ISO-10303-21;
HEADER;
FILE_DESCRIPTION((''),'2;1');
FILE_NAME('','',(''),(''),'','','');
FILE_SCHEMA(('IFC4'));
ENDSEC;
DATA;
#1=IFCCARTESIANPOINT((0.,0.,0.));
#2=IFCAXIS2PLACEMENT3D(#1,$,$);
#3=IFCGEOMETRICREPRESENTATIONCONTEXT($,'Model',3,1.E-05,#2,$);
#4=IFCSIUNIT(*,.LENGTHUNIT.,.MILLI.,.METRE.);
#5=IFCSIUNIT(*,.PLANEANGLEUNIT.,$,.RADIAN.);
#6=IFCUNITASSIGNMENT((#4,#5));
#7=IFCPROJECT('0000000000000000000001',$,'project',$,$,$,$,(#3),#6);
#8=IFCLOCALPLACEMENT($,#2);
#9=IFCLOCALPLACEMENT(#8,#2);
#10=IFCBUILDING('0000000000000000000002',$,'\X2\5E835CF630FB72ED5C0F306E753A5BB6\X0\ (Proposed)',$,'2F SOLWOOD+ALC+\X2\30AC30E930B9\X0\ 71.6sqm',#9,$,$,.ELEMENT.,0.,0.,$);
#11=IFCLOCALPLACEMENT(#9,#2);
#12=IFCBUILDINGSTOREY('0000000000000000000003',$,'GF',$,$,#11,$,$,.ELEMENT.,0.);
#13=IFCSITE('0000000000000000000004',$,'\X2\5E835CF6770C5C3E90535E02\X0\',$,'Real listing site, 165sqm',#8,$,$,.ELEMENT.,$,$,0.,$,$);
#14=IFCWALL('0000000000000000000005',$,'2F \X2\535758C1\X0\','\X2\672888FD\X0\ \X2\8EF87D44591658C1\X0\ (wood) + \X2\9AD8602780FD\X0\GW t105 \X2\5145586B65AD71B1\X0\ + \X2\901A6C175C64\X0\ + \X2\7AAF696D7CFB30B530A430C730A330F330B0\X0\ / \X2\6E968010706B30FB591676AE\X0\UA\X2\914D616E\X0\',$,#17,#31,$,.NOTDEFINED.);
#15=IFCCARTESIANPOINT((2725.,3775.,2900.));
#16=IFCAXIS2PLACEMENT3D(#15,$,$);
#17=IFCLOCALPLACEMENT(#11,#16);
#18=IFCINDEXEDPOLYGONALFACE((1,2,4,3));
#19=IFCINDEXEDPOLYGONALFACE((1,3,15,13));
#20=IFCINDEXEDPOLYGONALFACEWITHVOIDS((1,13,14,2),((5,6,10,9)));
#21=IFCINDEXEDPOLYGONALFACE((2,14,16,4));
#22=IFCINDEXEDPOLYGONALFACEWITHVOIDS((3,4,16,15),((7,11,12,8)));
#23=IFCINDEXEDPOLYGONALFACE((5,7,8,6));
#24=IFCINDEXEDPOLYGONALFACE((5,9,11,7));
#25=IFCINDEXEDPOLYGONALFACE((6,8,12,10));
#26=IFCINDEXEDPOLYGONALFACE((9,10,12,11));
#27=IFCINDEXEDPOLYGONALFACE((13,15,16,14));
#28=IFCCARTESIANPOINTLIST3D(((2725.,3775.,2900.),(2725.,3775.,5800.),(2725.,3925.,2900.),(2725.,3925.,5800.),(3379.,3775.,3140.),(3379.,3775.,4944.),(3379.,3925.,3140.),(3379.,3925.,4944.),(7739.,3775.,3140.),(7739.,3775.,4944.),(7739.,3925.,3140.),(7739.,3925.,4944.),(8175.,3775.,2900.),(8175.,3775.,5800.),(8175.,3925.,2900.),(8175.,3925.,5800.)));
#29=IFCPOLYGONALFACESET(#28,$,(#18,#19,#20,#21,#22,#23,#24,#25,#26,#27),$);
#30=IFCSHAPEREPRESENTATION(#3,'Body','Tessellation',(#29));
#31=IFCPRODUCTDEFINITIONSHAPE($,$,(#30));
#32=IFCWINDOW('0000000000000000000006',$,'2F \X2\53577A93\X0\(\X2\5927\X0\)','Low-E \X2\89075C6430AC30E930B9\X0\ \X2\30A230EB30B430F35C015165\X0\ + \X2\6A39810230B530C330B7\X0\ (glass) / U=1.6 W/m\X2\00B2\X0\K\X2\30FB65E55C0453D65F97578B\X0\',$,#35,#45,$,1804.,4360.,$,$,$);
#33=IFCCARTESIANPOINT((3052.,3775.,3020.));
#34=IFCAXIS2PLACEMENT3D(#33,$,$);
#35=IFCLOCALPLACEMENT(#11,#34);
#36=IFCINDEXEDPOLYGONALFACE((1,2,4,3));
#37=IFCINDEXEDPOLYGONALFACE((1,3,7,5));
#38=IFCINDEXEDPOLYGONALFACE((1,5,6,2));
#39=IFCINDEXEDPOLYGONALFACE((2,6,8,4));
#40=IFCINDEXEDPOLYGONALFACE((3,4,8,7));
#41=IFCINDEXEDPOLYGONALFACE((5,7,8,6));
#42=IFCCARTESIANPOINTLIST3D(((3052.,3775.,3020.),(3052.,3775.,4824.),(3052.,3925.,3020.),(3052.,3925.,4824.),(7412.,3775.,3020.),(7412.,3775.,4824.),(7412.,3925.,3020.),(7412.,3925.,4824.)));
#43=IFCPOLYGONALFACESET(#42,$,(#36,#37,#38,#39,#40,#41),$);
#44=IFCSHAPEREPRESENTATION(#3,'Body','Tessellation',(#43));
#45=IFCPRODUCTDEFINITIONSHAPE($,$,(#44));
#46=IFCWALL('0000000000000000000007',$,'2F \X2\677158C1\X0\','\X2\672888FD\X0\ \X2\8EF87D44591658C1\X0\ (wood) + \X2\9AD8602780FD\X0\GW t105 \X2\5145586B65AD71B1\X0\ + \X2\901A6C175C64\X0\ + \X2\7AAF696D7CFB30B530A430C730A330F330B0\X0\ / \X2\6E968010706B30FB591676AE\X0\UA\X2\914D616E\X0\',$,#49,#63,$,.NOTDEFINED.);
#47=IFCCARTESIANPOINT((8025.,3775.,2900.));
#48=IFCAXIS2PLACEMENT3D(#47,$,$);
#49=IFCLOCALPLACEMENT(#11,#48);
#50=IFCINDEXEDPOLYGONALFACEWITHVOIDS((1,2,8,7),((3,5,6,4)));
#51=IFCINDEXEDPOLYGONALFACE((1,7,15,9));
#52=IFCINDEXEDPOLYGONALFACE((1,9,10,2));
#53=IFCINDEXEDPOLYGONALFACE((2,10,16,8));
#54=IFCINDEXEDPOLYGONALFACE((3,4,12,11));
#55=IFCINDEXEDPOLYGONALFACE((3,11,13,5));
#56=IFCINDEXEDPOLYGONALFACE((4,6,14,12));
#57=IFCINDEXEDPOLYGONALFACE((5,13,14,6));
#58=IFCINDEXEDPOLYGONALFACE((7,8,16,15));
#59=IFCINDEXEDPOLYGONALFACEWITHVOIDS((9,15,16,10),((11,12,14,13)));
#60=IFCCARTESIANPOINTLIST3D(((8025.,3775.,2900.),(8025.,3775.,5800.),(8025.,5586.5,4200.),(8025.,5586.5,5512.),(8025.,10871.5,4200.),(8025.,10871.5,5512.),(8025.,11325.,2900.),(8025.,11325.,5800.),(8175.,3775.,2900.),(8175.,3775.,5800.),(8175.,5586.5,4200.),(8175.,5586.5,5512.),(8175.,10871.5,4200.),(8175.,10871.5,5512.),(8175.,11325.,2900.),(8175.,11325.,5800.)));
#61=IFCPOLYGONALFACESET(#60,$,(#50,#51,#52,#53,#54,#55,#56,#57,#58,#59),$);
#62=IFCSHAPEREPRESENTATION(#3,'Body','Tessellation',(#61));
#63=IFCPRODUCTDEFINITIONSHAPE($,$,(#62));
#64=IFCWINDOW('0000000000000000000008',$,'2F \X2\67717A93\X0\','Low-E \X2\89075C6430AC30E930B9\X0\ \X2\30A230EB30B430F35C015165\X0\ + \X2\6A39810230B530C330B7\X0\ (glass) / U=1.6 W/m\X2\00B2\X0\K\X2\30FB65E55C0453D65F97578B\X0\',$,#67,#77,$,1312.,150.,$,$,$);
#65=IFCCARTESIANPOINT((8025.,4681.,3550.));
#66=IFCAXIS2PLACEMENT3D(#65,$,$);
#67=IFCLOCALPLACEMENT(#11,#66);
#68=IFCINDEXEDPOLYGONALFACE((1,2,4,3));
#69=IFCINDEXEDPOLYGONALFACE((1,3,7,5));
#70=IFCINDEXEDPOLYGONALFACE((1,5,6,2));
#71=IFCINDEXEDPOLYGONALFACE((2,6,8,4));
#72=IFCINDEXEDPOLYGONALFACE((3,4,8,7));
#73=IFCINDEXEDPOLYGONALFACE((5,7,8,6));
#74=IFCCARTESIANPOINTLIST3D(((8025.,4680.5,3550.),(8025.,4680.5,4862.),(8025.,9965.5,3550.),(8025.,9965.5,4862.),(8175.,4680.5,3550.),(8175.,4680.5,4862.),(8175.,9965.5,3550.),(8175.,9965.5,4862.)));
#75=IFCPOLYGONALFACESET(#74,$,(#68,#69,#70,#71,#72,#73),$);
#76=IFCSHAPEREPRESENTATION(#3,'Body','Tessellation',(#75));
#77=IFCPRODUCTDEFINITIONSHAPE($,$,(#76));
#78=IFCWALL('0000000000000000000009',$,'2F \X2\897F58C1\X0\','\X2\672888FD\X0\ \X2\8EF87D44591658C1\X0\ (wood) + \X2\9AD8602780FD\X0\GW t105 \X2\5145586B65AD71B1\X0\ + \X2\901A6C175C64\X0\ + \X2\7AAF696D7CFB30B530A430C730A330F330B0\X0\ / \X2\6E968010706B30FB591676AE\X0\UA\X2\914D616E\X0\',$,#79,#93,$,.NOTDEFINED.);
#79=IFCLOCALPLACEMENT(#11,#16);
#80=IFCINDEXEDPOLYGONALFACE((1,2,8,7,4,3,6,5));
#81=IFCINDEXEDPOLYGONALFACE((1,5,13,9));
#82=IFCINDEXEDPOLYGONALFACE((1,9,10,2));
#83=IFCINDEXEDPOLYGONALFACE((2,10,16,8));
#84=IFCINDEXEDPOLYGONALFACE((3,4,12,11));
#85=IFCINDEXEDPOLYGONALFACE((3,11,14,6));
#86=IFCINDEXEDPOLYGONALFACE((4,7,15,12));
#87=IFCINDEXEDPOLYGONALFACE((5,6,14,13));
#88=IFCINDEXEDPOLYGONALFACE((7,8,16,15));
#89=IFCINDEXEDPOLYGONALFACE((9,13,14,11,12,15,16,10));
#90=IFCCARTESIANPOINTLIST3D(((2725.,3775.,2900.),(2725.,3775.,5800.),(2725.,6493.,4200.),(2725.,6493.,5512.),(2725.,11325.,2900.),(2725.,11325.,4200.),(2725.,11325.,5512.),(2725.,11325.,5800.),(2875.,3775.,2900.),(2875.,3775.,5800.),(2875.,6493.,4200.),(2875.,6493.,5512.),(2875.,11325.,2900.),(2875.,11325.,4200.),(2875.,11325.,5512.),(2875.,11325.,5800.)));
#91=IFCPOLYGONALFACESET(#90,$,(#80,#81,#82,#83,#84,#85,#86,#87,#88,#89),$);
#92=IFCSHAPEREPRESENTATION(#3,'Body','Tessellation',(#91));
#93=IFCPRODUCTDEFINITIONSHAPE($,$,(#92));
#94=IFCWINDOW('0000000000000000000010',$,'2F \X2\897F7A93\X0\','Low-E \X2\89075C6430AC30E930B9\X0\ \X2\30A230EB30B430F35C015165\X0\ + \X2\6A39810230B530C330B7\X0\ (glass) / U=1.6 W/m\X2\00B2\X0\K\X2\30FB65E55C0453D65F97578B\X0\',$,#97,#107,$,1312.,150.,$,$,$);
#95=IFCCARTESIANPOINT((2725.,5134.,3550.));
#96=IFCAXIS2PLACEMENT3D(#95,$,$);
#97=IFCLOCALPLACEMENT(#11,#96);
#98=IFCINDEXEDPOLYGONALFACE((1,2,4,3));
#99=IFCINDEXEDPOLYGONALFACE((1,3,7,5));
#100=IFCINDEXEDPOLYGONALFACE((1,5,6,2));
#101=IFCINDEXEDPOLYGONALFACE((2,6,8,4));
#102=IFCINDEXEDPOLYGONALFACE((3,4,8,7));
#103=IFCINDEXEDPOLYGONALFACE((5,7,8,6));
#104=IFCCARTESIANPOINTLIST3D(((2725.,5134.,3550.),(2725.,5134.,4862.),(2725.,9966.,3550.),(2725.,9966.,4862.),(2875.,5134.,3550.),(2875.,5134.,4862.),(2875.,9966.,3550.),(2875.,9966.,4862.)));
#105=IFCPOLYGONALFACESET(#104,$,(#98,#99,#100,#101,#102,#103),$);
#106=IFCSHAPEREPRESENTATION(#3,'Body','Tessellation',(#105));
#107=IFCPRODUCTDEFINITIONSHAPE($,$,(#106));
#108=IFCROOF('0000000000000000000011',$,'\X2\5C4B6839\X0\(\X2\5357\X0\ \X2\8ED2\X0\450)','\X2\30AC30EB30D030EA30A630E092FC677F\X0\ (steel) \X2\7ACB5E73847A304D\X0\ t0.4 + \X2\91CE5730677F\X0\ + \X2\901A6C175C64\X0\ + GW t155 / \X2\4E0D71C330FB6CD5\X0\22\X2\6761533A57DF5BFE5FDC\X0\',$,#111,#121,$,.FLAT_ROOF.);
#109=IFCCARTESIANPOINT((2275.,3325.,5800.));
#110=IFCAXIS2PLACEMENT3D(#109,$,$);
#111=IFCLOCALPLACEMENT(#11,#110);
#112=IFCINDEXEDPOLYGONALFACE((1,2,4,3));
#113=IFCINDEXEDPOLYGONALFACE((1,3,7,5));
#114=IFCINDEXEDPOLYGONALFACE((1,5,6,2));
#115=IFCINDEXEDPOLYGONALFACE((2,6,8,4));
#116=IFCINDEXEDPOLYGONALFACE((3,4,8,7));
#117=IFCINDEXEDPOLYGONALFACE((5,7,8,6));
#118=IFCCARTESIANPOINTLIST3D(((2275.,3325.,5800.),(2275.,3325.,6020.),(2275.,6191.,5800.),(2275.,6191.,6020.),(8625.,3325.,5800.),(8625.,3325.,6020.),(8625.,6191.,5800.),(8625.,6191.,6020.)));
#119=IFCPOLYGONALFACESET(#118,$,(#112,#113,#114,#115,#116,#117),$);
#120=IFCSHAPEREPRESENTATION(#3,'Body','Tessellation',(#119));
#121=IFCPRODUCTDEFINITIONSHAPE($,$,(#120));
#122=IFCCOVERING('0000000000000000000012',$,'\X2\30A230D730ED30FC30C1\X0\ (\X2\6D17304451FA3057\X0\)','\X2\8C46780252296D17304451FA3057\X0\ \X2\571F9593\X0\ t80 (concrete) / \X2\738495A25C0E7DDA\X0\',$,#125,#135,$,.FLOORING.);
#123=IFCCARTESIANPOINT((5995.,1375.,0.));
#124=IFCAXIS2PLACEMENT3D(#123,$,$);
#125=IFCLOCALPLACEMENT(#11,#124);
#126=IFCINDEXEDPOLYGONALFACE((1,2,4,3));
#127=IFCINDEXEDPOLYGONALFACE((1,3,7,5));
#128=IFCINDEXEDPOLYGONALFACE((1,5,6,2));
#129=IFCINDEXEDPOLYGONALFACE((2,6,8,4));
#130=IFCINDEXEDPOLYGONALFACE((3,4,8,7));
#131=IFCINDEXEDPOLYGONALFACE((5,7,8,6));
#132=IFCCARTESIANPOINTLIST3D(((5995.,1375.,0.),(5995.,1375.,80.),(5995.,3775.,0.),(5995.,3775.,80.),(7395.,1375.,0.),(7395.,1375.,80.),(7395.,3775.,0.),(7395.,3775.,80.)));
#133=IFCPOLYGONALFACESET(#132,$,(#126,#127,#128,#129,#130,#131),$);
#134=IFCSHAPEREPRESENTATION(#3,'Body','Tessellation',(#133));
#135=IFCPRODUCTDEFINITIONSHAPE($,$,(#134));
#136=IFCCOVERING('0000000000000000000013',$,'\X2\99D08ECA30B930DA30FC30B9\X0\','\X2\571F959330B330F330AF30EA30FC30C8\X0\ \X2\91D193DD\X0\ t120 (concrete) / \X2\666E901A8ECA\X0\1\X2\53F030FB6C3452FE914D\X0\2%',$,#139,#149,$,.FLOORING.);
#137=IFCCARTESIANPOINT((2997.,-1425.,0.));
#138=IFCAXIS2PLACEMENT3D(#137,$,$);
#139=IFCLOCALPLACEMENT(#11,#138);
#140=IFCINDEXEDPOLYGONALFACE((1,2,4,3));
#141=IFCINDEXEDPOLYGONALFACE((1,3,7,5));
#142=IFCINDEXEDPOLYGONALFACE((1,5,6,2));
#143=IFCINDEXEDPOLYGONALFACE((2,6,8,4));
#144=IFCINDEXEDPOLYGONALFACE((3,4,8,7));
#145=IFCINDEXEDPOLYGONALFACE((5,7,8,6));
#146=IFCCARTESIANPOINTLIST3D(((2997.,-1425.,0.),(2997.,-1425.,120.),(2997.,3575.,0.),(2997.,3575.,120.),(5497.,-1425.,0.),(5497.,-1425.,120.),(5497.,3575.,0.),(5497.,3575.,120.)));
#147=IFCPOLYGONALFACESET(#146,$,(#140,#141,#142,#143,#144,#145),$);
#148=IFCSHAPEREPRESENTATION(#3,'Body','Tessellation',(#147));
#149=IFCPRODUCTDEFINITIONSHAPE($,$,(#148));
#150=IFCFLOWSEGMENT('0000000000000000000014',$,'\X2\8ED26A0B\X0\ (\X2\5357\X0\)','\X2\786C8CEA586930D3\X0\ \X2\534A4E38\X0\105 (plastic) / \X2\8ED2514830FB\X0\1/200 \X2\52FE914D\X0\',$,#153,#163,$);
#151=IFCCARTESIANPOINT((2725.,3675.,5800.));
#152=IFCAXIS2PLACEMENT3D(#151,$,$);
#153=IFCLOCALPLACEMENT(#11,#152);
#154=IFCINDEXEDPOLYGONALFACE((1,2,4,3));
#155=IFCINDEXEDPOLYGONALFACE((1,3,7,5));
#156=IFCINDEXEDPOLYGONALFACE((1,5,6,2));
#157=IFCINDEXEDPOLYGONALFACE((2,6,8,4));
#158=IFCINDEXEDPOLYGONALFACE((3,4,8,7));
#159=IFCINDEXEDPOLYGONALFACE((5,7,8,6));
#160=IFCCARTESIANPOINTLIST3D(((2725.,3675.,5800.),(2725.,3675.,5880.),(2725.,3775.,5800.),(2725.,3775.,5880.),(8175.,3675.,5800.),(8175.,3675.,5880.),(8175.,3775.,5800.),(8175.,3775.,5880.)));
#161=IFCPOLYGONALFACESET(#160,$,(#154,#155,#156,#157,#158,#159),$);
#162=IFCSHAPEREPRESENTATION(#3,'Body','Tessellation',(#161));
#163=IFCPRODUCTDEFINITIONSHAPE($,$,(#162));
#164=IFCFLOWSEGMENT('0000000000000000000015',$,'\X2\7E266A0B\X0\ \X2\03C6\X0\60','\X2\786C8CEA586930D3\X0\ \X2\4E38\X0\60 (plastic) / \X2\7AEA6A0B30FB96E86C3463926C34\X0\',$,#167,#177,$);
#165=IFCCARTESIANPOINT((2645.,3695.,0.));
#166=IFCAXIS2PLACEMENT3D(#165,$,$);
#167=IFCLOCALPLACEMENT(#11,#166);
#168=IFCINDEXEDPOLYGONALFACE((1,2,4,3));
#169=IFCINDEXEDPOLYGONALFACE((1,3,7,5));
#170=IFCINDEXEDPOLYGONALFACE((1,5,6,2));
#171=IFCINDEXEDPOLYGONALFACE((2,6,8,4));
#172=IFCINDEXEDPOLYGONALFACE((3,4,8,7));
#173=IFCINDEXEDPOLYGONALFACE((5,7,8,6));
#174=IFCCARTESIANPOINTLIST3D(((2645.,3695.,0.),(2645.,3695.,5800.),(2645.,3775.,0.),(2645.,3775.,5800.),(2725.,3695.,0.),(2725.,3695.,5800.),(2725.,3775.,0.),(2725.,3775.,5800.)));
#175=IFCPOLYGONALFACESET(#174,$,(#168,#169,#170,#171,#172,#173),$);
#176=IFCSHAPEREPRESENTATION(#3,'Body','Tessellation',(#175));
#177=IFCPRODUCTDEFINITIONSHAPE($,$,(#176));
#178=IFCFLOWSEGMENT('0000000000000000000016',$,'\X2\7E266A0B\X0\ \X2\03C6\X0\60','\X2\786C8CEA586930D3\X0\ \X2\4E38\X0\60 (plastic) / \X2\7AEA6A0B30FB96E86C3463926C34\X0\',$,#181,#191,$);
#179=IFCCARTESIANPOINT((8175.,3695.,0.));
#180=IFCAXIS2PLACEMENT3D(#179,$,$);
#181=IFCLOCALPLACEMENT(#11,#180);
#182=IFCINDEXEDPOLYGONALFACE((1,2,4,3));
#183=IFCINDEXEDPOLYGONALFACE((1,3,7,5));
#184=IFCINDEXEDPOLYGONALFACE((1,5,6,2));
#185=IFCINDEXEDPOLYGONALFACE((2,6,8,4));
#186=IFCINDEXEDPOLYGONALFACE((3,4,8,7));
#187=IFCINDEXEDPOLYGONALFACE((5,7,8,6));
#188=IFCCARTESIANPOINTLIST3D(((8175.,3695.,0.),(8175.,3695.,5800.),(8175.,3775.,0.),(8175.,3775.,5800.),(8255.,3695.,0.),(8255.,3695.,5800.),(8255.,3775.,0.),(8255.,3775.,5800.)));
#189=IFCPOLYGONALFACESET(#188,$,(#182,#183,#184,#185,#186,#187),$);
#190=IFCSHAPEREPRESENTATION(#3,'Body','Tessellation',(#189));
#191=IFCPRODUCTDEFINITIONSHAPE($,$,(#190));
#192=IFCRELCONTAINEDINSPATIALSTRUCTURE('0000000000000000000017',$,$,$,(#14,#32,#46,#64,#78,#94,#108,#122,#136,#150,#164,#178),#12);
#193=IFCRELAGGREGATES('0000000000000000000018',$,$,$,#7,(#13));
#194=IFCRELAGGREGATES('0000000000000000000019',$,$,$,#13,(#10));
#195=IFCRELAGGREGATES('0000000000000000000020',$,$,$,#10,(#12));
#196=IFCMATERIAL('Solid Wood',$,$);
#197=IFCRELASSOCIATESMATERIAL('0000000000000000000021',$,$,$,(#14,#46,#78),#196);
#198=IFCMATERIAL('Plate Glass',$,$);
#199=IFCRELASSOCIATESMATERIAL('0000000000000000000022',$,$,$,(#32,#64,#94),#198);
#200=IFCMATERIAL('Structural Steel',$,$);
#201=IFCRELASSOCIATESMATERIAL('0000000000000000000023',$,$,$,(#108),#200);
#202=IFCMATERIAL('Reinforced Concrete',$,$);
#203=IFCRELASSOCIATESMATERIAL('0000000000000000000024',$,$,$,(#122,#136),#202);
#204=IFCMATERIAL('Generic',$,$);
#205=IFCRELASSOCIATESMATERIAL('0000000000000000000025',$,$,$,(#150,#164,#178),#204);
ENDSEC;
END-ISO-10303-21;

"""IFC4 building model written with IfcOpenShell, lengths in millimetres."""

from ifc_helpers import new_model, si_unit, frame, frame_2d, origin, place, context, project, spatial, rectangle, extrude, material, element, fill, save


model = new_model("IFC4")

# Units and contexts
model_context = context("Model", 3, precision=1e-05, world=origin())
ifc_project = project(units=[si_unit("LENGTHUNIT", "METRE", prefix="MILLI"), si_unit("PLANEANGLEUNIT", "RADIAN")], contexts=[model_context])

# Site, building, storey
site_placement = place(None, origin())
site = spatial("IfcSite", under=ifc_project, at=site_placement, Name="広島県尾道市", ObjectType="Real listing site, 165sqm", CompositionType="ELEMENT", RefElevation=0.0)
building_placement = place(site_placement, origin())
building = spatial("IfcBuilding", under=site, at=building_placement, Name="広島・狭小の町家 (Proposed)", ObjectType="2F SOLWOOD+ALC+ガラス 71.6sqm", CompositionType="ELEMENT", ElevationOfRefHeight=0.0, ElevationOfTerrain=0.0)
storey_placement = place(building_placement, origin())
storey = spatial("IfcBuildingStorey", under=building, at=storey_placement, Name="GF", CompositionType="ELEMENT", Elevation=0.0)

# Shared definitions
ifc_material_1 = material(Name="Solid Wood")

# Shared definitions
ifc_material_2 = material(Name="Reinforced Concrete")

# Shared definitions
ifc_material_3 = material(Name="Plate Glass")

# Walls, openings, windows
wall_1_placement = place(storey_placement, frame((2725.0, 3775.0, 2900.0)))
wall_1 = element("IfcWall", 1, at=wall_1_placement, inside=storey, material=ifc_material_1, Name="2F 南壁", Description="木製 軸組外壁 (wood) + 高性能GW t105 充填断熱 + 通気層 + 窯業系サイディング / 準耐火・外皮UA配慮", PredefinedType="NOTDEFINED", context=model_context, shape_type="SweptSolid", body=[
    extrude(rectangle(XDim=5450.0, YDim=150.0, at=frame_2d((2725.0, 75.0))), frame((2725.0, 3775.0, 2900.0)), (0.0, 0.0, 1.0), 2900.0),
])
opening_1_placement = place(storey_placement, frame((3052.0, 3775.0, 3020.0)))
opening_1 = element("IfcOpeningElement", 2, at=opening_1_placement, cuts=wall_1, PredefinedType="NOTDEFINED", context=model_context, shape_type="SweptSolid", body=[
    extrude(rectangle(XDim=4360.0, YDim=150.0, at=frame_2d((2180.0, 75.0))), frame((3052.0, 3775.0, 3020.0)), (0.0, 0.0, 1.0), 1804.0),
])
window_1_placement = place(storey_placement, frame((3052.0, 3775.0, 3020.0)))
window_1 = element("IfcWindow", 3, at=window_1_placement, inside=storey, material=ifc_material_3, Name="2F 南窓(大)", Description="Low-E 複層ガラス アルゴン封入 + 樹脂サッシ (glass) / U=1.6 W/m²K・日射取得型", OverallHeight=1804.0, OverallWidth=4360.0, context=model_context, shape_type="SweptSolid", body=[
    extrude(rectangle(XDim=4360.0, YDim=150.0, at=frame_2d((2180.0, 75.0))), frame((3052.0, 3775.0, 3020.0)), (0.0, 0.0, 1.0), 1804.0),
])
fill(opening_1, window_1)
wall_2_placement = place(storey_placement, frame((8025.0, 3775.0, 2900.0)))
wall_2 = element("IfcWall", 4, at=wall_2_placement, inside=storey, material=ifc_material_1, Name="2F 東壁", Description="木製 軸組外壁 (wood) + 高性能GW t105 充填断熱 + 通気層 + 窯業系サイディング / 準耐火・外皮UA配慮", PredefinedType="NOTDEFINED", context=model_context, shape_type="SweptSolid", body=[
    extrude(rectangle(XDim=150.0, YDim=7550.0, at=frame_2d((75.0, 3775.0))), frame((8025.0, 3775.0, 2900.0)), (0.0, 0.0, 1.0), 2900.0),
])
opening_2_placement = place(storey_placement, frame((8025.0, 4681.0, 3550.0)))
opening_2 = element("IfcOpeningElement", 5, at=opening_2_placement, cuts=wall_2, PredefinedType="NOTDEFINED", context=model_context, shape_type="SweptSolid", body=[
    extrude(rectangle(XDim=150.0, YDim=5285.0, at=frame_2d((75.0, 2642.0))), frame((8025.0, 4681.0, 3550.0)), (0.0, 0.0, 1.0), 1312.0),
])
window_2_placement = place(storey_placement, frame((8025.0, 4681.0, 3550.0)))
window_2 = element("IfcWindow", 6, at=window_2_placement, inside=storey, material=ifc_material_3, Name="2F 東窓", Description="Low-E 複層ガラス アルゴン封入 + 樹脂サッシ (glass) / U=1.6 W/m²K・日射取得型", OverallHeight=1312.0, OverallWidth=150.0, context=model_context, shape_type="SweptSolid", body=[
    extrude(rectangle(XDim=150.0, YDim=5285.0, at=frame_2d((75.0, 2642.0))), frame((8025.0, 4681.0, 3550.0)), (0.0, 0.0, 1.0), 1312.0),
])
fill(opening_2, window_2)
wall_3_placement = place(storey_placement, frame((2725.0, 3775.0, 2900.0)))
wall_3 = element("IfcWall", 7, at=wall_3_placement, inside=storey, material=ifc_material_1, Name="2F 西壁", Description="木製 軸組外壁 (wood) + 高性能GW t105 充填断熱 + 通気層 + 窯業系サイディング / 準耐火・外皮UA配慮", PredefinedType="NOTDEFINED", context=model_context, shape_type="SweptSolid", body=[
    extrude(rectangle(XDim=150.0, YDim=7550.0, at=frame_2d((75.0, 3775.0))), frame((2725.0, 3775.0, 2900.0)), (0.0, 0.0, 1.0), 2900.0),
])
opening_3_placement = place(storey_placement, frame((2725.0, 5134.0, 3550.0)))
opening_3 = element("IfcOpeningElement", 8, at=opening_3_placement, cuts=wall_3, PredefinedType="NOTDEFINED", context=model_context, shape_type="SweptSolid", body=[
    extrude(rectangle(XDim=150.0, YDim=4832.0, at=frame_2d((75.0, 2416.0))), frame((2725.0, 5134.0, 3550.0)), (0.0, 0.0, 1.0), 1312.0),
])
window_3_placement = place(storey_placement, frame((2725.0, 5134.0, 3550.0)))
window_3 = element("IfcWindow", 9, at=window_3_placement, inside=storey, material=ifc_material_3, Name="2F 西窓", Description="Low-E 複層ガラス アルゴン封入 + 樹脂サッシ (glass) / U=1.6 W/m²K・日射取得型", OverallHeight=1312.0, OverallWidth=150.0, context=model_context, shape_type="SweptSolid", body=[
    extrude(rectangle(XDim=150.0, YDim=4832.0, at=frame_2d((75.0, 2416.0))), frame((2725.0, 5134.0, 3550.0)), (0.0, 0.0, 1.0), 1312.0),
])
fill(opening_3, window_3)

# Roof
ifc_material_4 = material(Name="Structural Steel")
for number, where, name in (
    (10, (2275.0, 3325.0, 5800.0), "屋根(南 軒450)"),
):
    element("IfcRoof", number, at=place(storey_placement, frame(where)), inside=storey, material=ifc_material_4, Name=name, Description="ガルバリウム鋼板 (steel) 立平葺き t0.4 + 野地板 + 通気層 + GW t155 / 不燃・法22条区域対応", PredefinedType="FLAT_ROOF", context=model_context, shape_type="SweptSolid", body=[
        extrude(rectangle(XDim=6350.0, YDim=2866.0, at=frame_2d((3175.0, 1433.0))), frame((2275.0, 3325.0, 5800.0)), (0.0, 0.0, 1.0), 220.0),
    ])

# Coverings
covering_1_placement = place(storey_placement, frame((5995.0, 1375.0, 0.0)))
element("IfcCovering", 11, at=covering_1_placement, inside=storey, material=ifc_material_2, Name="アプローチ (洗い出し)", Description="豆砂利洗い出し 土間 t80 (concrete) / 玄関導線", PredefinedType="FLOORING", context=model_context, shape_type="SweptSolid", body=[
    extrude(rectangle(XDim=1400.0, YDim=2400.0, at=frame_2d((700.0, 1200.0))), frame((5995.0, 1375.0, 0.0)), (0.0, 0.0, 1.0), 80.0),
])
covering_2_placement = place(storey_placement, frame((2997.0, -1425.0, 0.0)))
element("IfcCovering", 12, at=covering_2_placement, inside=storey, material=ifc_material_2, Name="駐車スペース", Description="土間コンクリート 金鏝 t120 (concrete) / 普通車1台・水勾配2%", PredefinedType="FLOORING", context=model_context, shape_type="SweptSolid", body=[
    extrude(rectangle(XDim=2500.0, YDim=5000.0, at=frame_2d((1250.0, 2500.0))), frame((2997.0, -1425.0, 0.0)), (0.0, 0.0, 1.0), 120.0),
])

# Flow segments
ifc_material_5 = material(Name="Generic")
flow_segment_1_placement = place(storey_placement, frame((2725.0, 3675.0, 5800.0)))
element("IfcFlowSegment", 13, at=flow_segment_1_placement, inside=storey, material=ifc_material_5, Name="軒樋 (南)", Description="硬質塩ビ 半丸105 (plastic) / 軒先・1/200 勾配", context=model_context, shape_type="SweptSolid", body=[
    extrude(rectangle(XDim=5450.0, YDim=100.0, at=frame_2d((2725.0, 50.0))), frame((2725.0, 3675.0, 5800.0)), (0.0, 0.0, 1.0), 80.0),
])
flow_segment_2_placement = place(storey_placement, frame((2645.0, 3695.0, 0.0)))
element("IfcFlowSegment", 14, at=flow_segment_2_placement, inside=storey, material=ifc_material_5, Name="縦樋 φ60", Description="硬質塩ビ 丸60 (plastic) / 竪樋・雨水排水", context=model_context, shape_type="SweptSolid", body=[
    extrude(rectangle(XDim=80.0, YDim=80.0, at=frame_2d((40.0, 40.0))), frame((2645.0, 3695.0, 0.0)), (0.0, 0.0, 1.0), 5800.0),
])
flow_segment_3_placement = place(storey_placement, frame((8175.0, 3695.0, 0.0)))
element("IfcFlowSegment", 15, at=flow_segment_3_placement, inside=storey, material=ifc_material_5, Name="縦樋 φ60", Description="硬質塩ビ 丸60 (plastic) / 竪樋・雨水排水", context=model_context, shape_type="SweptSolid", body=[
    extrude(rectangle(XDim=80.0, YDim=80.0, at=frame_2d((40.0, 40.0))), frame((8175.0, 3695.0, 0.0)), (0.0, 0.0, 1.0), 5800.0),
])

save(model, "model.ifc")
